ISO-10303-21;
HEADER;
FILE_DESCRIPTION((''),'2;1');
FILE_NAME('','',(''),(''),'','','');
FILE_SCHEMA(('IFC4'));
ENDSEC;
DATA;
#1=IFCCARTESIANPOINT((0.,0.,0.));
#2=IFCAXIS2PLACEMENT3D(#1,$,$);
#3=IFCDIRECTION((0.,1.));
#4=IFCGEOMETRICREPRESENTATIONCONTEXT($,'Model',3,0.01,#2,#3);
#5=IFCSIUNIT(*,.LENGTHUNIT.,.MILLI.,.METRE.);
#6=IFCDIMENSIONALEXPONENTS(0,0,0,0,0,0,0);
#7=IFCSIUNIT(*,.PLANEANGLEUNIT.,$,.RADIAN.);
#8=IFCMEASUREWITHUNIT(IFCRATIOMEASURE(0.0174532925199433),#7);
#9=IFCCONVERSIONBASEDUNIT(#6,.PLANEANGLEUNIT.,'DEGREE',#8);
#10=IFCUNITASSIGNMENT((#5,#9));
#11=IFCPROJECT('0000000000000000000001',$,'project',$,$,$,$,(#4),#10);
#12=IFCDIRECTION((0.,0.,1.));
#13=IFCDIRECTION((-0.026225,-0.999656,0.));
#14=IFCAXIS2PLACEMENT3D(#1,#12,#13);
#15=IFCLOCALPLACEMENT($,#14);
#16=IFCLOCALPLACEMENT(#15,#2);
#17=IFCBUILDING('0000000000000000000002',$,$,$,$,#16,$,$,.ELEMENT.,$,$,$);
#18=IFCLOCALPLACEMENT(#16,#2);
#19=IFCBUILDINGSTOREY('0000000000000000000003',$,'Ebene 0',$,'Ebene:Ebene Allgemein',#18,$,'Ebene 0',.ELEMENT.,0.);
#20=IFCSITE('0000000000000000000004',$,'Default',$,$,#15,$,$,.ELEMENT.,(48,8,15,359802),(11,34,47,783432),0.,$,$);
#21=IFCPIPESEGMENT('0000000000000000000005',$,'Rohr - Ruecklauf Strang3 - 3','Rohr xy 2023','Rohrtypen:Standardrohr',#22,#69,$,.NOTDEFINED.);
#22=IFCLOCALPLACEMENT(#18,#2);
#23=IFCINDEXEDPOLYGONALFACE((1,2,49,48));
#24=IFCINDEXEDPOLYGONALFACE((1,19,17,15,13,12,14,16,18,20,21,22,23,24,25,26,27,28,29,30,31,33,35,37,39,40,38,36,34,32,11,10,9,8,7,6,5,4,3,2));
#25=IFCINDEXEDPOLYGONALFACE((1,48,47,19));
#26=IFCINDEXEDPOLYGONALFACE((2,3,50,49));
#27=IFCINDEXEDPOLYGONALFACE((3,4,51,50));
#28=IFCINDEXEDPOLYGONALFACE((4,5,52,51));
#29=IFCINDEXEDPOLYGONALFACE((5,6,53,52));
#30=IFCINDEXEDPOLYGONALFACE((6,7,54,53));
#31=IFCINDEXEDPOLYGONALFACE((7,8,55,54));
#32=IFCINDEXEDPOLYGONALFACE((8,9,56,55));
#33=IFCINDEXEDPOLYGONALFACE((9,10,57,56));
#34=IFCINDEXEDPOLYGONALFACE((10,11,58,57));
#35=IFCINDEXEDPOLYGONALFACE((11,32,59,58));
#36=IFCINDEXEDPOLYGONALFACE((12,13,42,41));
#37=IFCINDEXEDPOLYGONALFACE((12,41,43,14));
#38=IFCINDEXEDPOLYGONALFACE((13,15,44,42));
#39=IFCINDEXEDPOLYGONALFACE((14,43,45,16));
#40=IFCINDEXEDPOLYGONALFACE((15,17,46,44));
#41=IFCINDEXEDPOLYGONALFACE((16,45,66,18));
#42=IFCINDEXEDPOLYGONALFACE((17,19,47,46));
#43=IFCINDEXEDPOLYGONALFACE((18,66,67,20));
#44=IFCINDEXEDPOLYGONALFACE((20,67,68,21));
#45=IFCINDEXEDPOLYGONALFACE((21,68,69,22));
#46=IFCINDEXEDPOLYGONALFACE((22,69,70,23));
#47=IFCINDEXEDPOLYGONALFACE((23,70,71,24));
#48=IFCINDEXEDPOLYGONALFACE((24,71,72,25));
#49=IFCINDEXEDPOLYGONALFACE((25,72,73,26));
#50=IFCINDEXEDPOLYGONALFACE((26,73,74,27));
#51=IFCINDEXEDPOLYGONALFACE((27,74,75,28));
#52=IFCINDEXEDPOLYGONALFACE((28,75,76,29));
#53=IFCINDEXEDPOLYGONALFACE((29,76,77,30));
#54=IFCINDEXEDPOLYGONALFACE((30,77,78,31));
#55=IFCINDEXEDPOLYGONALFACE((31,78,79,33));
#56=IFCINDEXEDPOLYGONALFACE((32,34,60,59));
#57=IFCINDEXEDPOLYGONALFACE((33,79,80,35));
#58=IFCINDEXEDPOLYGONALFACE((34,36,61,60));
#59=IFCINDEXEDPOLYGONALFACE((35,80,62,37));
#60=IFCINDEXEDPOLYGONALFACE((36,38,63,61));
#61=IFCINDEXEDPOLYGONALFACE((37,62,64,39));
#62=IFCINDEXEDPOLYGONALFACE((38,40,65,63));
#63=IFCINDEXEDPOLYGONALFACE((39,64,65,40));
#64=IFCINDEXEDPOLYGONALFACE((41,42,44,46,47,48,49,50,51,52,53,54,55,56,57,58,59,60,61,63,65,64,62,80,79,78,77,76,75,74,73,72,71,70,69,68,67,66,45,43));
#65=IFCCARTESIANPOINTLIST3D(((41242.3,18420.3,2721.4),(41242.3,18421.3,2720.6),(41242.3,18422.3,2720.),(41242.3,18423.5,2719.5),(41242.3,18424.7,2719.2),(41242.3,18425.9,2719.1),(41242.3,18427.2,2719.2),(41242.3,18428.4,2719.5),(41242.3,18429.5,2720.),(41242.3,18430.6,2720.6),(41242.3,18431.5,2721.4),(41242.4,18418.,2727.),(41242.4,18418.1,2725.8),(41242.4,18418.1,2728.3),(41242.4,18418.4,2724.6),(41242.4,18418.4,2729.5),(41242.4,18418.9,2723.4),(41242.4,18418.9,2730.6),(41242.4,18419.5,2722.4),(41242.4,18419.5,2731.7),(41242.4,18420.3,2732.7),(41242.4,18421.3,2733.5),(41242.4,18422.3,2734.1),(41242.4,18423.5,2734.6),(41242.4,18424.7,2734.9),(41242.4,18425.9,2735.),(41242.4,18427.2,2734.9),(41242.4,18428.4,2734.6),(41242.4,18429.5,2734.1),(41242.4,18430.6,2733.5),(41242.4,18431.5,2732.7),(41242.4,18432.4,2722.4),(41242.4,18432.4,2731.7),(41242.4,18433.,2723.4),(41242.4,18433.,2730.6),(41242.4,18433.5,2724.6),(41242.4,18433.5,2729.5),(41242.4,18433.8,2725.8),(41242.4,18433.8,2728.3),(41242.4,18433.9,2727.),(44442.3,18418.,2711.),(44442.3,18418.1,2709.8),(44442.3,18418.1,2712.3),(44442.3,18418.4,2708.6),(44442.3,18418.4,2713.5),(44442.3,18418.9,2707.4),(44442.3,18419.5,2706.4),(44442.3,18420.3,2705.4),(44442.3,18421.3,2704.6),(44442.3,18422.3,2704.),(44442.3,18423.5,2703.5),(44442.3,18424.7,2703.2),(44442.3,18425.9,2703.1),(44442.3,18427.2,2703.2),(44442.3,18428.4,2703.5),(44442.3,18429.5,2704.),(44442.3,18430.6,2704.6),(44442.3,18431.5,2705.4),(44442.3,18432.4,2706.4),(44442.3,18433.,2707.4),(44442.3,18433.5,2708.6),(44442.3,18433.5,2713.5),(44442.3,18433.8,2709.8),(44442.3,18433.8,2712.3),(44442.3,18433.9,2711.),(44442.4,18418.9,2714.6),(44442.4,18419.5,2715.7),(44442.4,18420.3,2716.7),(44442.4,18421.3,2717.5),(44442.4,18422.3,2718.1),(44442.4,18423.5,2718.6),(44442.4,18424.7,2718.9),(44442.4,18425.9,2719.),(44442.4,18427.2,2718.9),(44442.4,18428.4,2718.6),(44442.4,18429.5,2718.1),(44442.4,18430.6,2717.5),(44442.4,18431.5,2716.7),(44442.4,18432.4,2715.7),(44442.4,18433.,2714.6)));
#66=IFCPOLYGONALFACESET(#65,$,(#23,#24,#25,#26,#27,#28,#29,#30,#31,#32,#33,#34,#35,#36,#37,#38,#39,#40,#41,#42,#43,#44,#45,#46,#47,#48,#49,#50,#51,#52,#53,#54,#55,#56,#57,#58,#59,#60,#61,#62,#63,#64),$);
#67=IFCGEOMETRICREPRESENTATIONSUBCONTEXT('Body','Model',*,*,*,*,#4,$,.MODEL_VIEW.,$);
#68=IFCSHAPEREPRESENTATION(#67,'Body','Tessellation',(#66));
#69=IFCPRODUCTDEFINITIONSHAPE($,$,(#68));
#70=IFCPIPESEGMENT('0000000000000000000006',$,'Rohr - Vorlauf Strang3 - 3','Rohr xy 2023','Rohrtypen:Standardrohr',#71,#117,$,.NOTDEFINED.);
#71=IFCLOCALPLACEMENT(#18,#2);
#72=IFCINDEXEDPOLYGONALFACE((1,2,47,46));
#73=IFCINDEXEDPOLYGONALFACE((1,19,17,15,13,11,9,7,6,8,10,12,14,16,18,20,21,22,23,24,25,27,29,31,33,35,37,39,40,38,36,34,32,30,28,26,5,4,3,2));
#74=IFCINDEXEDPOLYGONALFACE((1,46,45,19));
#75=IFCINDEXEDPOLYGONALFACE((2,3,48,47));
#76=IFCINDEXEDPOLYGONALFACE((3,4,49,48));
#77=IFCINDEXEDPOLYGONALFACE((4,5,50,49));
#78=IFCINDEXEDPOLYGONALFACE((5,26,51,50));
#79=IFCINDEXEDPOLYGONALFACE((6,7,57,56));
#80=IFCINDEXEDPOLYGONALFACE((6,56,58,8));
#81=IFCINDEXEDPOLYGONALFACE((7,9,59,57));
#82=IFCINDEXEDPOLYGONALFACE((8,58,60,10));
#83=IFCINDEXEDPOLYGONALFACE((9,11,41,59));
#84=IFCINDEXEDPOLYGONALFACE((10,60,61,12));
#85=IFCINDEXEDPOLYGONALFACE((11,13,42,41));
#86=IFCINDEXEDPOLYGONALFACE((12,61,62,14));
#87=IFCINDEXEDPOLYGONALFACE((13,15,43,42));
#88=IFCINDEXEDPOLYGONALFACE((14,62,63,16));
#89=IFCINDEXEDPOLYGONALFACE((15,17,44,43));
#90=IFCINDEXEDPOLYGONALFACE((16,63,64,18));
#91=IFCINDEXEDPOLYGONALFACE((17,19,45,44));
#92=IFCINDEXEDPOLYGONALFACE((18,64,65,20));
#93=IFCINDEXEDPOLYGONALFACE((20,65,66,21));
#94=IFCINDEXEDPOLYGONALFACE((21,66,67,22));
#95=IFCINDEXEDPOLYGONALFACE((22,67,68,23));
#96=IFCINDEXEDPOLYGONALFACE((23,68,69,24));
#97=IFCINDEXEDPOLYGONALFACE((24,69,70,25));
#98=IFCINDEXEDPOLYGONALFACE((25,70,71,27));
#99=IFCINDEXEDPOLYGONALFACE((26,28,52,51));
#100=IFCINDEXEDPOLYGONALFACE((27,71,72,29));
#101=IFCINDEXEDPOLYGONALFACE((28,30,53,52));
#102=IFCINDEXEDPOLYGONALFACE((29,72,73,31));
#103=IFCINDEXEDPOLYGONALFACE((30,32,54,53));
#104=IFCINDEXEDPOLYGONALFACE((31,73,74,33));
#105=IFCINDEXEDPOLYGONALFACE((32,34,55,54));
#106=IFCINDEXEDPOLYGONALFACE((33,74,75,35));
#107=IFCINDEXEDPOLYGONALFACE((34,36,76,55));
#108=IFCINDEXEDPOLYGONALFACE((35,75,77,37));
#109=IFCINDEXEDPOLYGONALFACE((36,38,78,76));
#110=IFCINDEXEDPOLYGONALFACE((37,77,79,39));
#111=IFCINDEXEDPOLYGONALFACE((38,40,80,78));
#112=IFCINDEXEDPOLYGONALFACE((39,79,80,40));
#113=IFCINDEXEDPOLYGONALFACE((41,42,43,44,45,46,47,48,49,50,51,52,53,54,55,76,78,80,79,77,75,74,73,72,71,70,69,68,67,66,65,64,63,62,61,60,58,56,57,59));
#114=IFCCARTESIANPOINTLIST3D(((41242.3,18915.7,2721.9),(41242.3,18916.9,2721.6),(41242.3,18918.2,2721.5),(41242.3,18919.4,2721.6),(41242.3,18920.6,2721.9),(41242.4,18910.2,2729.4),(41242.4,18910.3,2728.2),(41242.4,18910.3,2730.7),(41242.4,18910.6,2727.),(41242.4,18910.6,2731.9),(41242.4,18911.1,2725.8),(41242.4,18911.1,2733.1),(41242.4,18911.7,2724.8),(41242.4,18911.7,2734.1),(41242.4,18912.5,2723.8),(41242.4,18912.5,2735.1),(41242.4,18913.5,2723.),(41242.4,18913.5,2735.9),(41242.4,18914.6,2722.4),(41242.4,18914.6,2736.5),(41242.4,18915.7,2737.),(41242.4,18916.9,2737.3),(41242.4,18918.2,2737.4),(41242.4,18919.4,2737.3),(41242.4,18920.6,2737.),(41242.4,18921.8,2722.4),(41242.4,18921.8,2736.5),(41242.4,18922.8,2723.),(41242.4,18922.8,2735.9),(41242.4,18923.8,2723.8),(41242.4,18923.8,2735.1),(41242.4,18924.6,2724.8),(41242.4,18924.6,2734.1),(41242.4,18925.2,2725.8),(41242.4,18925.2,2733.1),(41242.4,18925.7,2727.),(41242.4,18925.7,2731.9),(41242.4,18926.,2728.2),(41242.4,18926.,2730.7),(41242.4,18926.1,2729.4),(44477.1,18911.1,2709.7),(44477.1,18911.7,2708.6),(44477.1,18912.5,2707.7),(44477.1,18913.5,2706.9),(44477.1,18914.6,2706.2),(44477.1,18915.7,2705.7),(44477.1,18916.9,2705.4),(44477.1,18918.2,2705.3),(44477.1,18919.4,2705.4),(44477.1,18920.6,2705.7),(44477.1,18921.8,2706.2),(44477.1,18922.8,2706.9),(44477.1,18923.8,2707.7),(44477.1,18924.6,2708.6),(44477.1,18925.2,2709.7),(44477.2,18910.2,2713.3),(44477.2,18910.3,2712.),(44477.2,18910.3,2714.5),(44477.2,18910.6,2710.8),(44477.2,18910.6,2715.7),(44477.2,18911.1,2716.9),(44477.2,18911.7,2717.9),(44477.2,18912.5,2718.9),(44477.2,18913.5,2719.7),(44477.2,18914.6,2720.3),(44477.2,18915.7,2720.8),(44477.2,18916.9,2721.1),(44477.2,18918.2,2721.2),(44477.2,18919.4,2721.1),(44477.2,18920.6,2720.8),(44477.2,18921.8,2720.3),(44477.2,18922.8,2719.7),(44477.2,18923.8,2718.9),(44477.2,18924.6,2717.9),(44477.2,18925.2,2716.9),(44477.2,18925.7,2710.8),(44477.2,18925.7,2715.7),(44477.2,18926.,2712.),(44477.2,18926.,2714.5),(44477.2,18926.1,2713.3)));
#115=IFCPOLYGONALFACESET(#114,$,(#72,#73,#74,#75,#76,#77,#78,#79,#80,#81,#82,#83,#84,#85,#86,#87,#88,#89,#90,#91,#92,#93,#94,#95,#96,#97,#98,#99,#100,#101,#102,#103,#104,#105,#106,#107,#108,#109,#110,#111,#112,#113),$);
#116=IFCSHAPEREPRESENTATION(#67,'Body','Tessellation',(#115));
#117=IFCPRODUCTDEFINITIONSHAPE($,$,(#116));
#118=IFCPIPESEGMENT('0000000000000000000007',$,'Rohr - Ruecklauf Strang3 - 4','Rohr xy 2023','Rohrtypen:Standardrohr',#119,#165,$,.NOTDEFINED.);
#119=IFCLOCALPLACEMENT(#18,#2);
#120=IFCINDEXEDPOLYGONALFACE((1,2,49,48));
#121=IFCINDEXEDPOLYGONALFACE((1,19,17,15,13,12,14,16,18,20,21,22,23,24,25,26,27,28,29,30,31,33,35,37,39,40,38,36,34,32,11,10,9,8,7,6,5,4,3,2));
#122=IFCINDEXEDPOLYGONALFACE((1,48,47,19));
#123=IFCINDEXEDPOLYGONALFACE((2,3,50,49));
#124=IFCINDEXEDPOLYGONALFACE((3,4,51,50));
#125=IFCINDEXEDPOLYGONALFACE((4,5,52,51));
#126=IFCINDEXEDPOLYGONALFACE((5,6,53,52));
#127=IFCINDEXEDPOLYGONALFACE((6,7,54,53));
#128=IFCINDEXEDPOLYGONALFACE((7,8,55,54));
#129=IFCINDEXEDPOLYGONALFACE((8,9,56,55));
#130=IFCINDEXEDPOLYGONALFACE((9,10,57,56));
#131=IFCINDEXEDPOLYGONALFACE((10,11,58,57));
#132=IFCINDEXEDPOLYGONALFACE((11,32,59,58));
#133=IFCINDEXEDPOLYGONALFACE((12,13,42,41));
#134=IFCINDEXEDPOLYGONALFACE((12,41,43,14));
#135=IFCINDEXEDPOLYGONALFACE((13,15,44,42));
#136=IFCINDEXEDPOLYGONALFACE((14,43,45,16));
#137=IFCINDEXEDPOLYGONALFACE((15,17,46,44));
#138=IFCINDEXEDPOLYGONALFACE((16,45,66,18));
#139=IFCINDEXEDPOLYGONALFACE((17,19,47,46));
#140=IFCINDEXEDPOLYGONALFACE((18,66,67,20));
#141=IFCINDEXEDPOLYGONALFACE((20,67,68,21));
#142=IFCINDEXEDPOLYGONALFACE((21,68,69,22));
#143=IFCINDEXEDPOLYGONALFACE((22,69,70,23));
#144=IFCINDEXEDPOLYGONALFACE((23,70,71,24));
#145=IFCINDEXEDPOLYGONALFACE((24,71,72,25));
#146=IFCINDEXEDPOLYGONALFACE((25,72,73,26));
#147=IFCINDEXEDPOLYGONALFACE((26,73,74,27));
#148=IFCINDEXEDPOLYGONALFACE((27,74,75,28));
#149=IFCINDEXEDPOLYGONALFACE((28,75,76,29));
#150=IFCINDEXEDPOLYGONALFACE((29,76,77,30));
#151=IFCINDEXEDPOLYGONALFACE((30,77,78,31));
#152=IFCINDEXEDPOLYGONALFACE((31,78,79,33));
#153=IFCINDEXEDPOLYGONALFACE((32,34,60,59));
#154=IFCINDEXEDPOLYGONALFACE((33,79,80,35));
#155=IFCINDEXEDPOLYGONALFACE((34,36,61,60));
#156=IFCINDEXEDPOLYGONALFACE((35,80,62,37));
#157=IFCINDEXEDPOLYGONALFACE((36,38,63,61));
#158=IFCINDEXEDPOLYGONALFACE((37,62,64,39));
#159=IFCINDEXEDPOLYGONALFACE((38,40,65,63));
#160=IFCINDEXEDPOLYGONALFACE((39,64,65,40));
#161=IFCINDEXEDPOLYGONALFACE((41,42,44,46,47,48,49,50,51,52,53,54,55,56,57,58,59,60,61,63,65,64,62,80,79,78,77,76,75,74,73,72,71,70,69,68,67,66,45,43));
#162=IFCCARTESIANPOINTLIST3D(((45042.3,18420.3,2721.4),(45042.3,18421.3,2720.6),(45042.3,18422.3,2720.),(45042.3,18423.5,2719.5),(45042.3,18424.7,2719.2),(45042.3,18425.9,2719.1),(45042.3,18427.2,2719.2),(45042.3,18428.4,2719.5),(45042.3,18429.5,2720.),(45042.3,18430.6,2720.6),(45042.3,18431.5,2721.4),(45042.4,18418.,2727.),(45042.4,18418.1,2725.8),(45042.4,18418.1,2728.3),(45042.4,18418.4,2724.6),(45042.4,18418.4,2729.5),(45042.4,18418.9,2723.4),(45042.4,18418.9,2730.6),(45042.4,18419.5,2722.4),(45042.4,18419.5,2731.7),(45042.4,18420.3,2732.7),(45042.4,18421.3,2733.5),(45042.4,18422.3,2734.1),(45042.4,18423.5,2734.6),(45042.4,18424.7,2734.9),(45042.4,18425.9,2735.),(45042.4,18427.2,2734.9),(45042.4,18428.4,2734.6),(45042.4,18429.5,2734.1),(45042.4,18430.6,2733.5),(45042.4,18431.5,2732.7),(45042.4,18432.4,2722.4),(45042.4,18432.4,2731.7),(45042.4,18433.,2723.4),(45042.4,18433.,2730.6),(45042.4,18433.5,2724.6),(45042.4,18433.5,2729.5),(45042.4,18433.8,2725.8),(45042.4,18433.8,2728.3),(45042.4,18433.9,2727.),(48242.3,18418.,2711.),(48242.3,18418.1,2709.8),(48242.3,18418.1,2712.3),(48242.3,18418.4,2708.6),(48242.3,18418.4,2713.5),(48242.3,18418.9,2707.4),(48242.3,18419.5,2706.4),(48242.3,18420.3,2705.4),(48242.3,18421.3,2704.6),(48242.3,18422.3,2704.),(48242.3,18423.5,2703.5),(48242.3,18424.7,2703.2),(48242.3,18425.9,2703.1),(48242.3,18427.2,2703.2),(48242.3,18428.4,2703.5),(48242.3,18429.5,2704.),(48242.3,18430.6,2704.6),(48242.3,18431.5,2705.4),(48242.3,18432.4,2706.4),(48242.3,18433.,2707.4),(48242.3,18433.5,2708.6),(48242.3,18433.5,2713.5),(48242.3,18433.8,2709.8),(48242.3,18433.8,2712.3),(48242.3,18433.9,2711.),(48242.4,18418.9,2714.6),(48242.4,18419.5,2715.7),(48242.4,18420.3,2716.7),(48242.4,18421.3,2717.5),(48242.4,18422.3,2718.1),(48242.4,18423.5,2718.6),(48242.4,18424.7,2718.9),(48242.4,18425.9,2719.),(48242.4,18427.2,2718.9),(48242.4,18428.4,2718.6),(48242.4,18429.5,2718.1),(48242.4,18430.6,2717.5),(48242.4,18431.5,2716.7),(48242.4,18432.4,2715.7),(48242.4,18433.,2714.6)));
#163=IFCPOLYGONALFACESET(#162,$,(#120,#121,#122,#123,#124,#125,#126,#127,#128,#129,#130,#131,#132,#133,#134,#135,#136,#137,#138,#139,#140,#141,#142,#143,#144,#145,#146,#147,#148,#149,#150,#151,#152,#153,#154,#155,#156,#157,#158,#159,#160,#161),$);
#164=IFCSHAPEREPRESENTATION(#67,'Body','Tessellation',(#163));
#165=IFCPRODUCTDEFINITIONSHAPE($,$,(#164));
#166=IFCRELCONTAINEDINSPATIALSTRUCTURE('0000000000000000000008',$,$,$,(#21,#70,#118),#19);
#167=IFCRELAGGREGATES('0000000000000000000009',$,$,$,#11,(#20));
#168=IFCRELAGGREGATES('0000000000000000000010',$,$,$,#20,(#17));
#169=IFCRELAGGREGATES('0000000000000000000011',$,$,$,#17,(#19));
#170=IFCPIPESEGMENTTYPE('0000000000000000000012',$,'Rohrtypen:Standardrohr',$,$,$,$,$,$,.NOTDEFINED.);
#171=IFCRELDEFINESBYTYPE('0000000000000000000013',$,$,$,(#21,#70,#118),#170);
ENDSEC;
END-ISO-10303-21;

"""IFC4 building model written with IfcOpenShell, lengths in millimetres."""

from ifc_helpers import new_model, entity, si_unit, converted_unit, direction, frame, origin, place, context, subcontext, project, spatial, indexed_curve, outline, extrude, type_object, element, save


model = new_model("IFC4")

# Units and contexts
model_context = context("Model", 3, precision=0.01, world=origin(), true_north=direction((0.0, 1.0)))
body_context = subcontext(model_context, "Body", "Model", "MODEL_VIEW")
ifc_project = project(units=[si_unit("LENGTHUNIT", "METRE", prefix="MILLI"), converted_unit("PLANEANGLEUNIT", "DEGREE", entity("IfcRatioMeasure", 0.0174532925199433), si_unit("PLANEANGLEUNIT", "RADIAN"), dimensions=[0, 0, 0, 0, 0, 0, 0])], contexts=[model_context])

# Site, building, storey
site_placement = place(None, frame((0.0, 0.0, 0.0), z_axis=(0.0, 0.0, 1.0), x_axis=(-0.026225, -0.999656, 0.0)))
site = spatial("IfcSite", under=ifc_project, at=site_placement, Name="Default", CompositionType="ELEMENT", RefLatitude=(48, 8, 15, 359802), RefLongitude=(11, 34, 47, 783432), RefElevation=0.0)
building_placement = place(site_placement, origin())
building = spatial("IfcBuilding", under=site, at=building_placement, CompositionType="ELEMENT")
storey_placement = place(building_placement, origin())
storey = spatial("IfcBuildingStorey", under=building, at=storey_placement, Name="Ebene 0", ObjectType="Ebene:Ebene Allgemein", LongName="Ebene 0", CompositionType="ELEMENT", Elevation=0.0)

# Pipe segments
pipe_segment_type = type_object("IfcPipeSegmentType", Name="Rohrtypen:Standardrohr", PredefinedType="NOTDEFINED")
pipe_segment_1_placement = place(storey_placement, origin())
element("IfcPipeSegment", 1, at=pipe_segment_1_placement, inside=storey, type_object=pipe_segment_type, Name="Rohr - Ruecklauf Strang3 - 3", Description="Rohr xy 2023", ObjectType="Rohrtypen:Standardrohr", PredefinedType="NOTDEFINED", context=body_context, shape_type="SweptSolid", body=[
    extrude(outline(indexed_curve([(7.9, 0.0), (7.8, 1.2), (7.6, 2.5), (7.1, 3.6), (6.4, 4.7), (5.6, 5.6), (4.7, 6.4), (3.6, 7.1), (2.5, 7.6), (1.2, 7.8), (0.0, 7.9), (-1.2, 7.8), (-2.5, 7.6), (-3.6, 7.1), (-4.7, 6.4), (-5.6, 5.6), (-6.4, 4.7), (-7.1, 3.6), (-7.6, 2.5), (-7.8, 1.2), (-7.9, 0.0), (-7.8, -1.2), (-7.6, -2.5), (-7.1, -3.6), (-6.4, -4.7), (-5.6, -5.6), (-4.7, -6.4), (-3.6, -7.1), (-2.5, -7.6), (-1.2, -7.8), (0.0, -7.9), (1.2, -7.8), (2.5, -7.6), (3.6, -7.1), (4.7, -6.4), (5.6, -5.6), (6.4, -4.7), (7.1, -3.6), (7.6, -2.5), (7.8, -1.2), (7.9, 0.0)], self_intersect=False)), frame((44442.3, 18425.9, 2711.0), z_axis=(-0.999988, 0.0, 0.005), x_axis=(0.0, 1.0, 0.0)), (0.0, 0.0, 1.0), 3200.0),
])
pipe_segment_2_placement = place(storey_placement, origin())
element("IfcPipeSegment", 2, at=pipe_segment_2_placement, inside=storey, type_object=pipe_segment_type, Name="Rohr - Vorlauf Strang3 - 3", Description="Rohr xy 2023", ObjectType="Rohrtypen:Standardrohr", PredefinedType="NOTDEFINED", context=body_context, shape_type="SweptSolid", body=[
    extrude(outline(indexed_curve([(7.9, 0.0), (7.8, 1.2), (7.6, 2.5), (7.1, 3.6), (6.4, 4.7), (5.6, 5.6), (4.7, 6.4), (3.6, 7.1), (2.5, 7.6), (1.2, 7.8), (0.0, 7.9), (-1.2, 7.8), (-2.5, 7.6), (-3.6, 7.1), (-4.7, 6.4), (-5.6, 5.6), (-6.4, 4.7), (-7.1, 3.6), (-7.6, 2.5), (-7.8, 1.2), (-7.9, 0.0), (-7.8, -1.2), (-7.6, -2.5), (-7.1, -3.6), (-6.4, -4.7), (-5.6, -5.6), (-4.7, -6.4), (-3.6, -7.1), (-2.5, -7.6), (-1.2, -7.8), (0.0, -7.9), (1.2, -7.8), (2.5, -7.6), (3.6, -7.1), (4.7, -6.4), (5.6, -5.6), (6.4, -4.7), (7.1, -3.6), (7.6, -2.5), (7.8, -1.2), (7.9, 0.0)], self_intersect=False)), frame((44477.2, 18918.2, 2713.3), z_axis=(-0.999988, 0.0, 0.005), x_axis=(0.0, 1.0, 0.0)), (0.0, 0.0, 1.0), 3234.8),
])
pipe_segment_3_placement = place(storey_placement, origin())
element("IfcPipeSegment", 3, at=pipe_segment_3_placement, inside=storey, type_object=pipe_segment_type, Name="Rohr - Ruecklauf Strang3 - 4", Description="Rohr xy 2023", ObjectType="Rohrtypen:Standardrohr", PredefinedType="NOTDEFINED", context=body_context, shape_type="SweptSolid", body=[
    extrude(outline(indexed_curve([(7.9, 0.0), (7.8, 1.2), (7.6, 2.5), (7.1, 3.6), (6.4, 4.7), (5.6, 5.6), (4.7, 6.4), (3.6, 7.1), (2.5, 7.6), (1.2, 7.8), (0.0, 7.9), (-1.2, 7.8), (-2.5, 7.6), (-3.6, 7.1), (-4.7, 6.4), (-5.6, 5.6), (-6.4, 4.7), (-7.1, 3.6), (-7.6, 2.5), (-7.8, 1.2), (-7.9, 0.0), (-7.8, -1.2), (-7.6, -2.5), (-7.1, -3.6), (-6.4, -4.7), (-5.6, -5.6), (-4.7, -6.4), (-3.6, -7.1), (-2.5, -7.6), (-1.2, -7.8), (0.0, -7.9), (1.2, -7.8), (2.5, -7.6), (3.6, -7.1), (4.7, -6.4), (5.6, -5.6), (6.4, -4.7), (7.1, -3.6), (7.6, -2.5), (7.8, -1.2), (7.9, 0.0)], self_intersect=False)), frame((48242.3, 18425.9, 2711.0), z_axis=(-0.999988, 0.0, 0.005), x_axis=(0.0, 1.0, 0.0)), (0.0, 0.0, 1.0), 3200.0),
])

save(model, "model.ifc")
